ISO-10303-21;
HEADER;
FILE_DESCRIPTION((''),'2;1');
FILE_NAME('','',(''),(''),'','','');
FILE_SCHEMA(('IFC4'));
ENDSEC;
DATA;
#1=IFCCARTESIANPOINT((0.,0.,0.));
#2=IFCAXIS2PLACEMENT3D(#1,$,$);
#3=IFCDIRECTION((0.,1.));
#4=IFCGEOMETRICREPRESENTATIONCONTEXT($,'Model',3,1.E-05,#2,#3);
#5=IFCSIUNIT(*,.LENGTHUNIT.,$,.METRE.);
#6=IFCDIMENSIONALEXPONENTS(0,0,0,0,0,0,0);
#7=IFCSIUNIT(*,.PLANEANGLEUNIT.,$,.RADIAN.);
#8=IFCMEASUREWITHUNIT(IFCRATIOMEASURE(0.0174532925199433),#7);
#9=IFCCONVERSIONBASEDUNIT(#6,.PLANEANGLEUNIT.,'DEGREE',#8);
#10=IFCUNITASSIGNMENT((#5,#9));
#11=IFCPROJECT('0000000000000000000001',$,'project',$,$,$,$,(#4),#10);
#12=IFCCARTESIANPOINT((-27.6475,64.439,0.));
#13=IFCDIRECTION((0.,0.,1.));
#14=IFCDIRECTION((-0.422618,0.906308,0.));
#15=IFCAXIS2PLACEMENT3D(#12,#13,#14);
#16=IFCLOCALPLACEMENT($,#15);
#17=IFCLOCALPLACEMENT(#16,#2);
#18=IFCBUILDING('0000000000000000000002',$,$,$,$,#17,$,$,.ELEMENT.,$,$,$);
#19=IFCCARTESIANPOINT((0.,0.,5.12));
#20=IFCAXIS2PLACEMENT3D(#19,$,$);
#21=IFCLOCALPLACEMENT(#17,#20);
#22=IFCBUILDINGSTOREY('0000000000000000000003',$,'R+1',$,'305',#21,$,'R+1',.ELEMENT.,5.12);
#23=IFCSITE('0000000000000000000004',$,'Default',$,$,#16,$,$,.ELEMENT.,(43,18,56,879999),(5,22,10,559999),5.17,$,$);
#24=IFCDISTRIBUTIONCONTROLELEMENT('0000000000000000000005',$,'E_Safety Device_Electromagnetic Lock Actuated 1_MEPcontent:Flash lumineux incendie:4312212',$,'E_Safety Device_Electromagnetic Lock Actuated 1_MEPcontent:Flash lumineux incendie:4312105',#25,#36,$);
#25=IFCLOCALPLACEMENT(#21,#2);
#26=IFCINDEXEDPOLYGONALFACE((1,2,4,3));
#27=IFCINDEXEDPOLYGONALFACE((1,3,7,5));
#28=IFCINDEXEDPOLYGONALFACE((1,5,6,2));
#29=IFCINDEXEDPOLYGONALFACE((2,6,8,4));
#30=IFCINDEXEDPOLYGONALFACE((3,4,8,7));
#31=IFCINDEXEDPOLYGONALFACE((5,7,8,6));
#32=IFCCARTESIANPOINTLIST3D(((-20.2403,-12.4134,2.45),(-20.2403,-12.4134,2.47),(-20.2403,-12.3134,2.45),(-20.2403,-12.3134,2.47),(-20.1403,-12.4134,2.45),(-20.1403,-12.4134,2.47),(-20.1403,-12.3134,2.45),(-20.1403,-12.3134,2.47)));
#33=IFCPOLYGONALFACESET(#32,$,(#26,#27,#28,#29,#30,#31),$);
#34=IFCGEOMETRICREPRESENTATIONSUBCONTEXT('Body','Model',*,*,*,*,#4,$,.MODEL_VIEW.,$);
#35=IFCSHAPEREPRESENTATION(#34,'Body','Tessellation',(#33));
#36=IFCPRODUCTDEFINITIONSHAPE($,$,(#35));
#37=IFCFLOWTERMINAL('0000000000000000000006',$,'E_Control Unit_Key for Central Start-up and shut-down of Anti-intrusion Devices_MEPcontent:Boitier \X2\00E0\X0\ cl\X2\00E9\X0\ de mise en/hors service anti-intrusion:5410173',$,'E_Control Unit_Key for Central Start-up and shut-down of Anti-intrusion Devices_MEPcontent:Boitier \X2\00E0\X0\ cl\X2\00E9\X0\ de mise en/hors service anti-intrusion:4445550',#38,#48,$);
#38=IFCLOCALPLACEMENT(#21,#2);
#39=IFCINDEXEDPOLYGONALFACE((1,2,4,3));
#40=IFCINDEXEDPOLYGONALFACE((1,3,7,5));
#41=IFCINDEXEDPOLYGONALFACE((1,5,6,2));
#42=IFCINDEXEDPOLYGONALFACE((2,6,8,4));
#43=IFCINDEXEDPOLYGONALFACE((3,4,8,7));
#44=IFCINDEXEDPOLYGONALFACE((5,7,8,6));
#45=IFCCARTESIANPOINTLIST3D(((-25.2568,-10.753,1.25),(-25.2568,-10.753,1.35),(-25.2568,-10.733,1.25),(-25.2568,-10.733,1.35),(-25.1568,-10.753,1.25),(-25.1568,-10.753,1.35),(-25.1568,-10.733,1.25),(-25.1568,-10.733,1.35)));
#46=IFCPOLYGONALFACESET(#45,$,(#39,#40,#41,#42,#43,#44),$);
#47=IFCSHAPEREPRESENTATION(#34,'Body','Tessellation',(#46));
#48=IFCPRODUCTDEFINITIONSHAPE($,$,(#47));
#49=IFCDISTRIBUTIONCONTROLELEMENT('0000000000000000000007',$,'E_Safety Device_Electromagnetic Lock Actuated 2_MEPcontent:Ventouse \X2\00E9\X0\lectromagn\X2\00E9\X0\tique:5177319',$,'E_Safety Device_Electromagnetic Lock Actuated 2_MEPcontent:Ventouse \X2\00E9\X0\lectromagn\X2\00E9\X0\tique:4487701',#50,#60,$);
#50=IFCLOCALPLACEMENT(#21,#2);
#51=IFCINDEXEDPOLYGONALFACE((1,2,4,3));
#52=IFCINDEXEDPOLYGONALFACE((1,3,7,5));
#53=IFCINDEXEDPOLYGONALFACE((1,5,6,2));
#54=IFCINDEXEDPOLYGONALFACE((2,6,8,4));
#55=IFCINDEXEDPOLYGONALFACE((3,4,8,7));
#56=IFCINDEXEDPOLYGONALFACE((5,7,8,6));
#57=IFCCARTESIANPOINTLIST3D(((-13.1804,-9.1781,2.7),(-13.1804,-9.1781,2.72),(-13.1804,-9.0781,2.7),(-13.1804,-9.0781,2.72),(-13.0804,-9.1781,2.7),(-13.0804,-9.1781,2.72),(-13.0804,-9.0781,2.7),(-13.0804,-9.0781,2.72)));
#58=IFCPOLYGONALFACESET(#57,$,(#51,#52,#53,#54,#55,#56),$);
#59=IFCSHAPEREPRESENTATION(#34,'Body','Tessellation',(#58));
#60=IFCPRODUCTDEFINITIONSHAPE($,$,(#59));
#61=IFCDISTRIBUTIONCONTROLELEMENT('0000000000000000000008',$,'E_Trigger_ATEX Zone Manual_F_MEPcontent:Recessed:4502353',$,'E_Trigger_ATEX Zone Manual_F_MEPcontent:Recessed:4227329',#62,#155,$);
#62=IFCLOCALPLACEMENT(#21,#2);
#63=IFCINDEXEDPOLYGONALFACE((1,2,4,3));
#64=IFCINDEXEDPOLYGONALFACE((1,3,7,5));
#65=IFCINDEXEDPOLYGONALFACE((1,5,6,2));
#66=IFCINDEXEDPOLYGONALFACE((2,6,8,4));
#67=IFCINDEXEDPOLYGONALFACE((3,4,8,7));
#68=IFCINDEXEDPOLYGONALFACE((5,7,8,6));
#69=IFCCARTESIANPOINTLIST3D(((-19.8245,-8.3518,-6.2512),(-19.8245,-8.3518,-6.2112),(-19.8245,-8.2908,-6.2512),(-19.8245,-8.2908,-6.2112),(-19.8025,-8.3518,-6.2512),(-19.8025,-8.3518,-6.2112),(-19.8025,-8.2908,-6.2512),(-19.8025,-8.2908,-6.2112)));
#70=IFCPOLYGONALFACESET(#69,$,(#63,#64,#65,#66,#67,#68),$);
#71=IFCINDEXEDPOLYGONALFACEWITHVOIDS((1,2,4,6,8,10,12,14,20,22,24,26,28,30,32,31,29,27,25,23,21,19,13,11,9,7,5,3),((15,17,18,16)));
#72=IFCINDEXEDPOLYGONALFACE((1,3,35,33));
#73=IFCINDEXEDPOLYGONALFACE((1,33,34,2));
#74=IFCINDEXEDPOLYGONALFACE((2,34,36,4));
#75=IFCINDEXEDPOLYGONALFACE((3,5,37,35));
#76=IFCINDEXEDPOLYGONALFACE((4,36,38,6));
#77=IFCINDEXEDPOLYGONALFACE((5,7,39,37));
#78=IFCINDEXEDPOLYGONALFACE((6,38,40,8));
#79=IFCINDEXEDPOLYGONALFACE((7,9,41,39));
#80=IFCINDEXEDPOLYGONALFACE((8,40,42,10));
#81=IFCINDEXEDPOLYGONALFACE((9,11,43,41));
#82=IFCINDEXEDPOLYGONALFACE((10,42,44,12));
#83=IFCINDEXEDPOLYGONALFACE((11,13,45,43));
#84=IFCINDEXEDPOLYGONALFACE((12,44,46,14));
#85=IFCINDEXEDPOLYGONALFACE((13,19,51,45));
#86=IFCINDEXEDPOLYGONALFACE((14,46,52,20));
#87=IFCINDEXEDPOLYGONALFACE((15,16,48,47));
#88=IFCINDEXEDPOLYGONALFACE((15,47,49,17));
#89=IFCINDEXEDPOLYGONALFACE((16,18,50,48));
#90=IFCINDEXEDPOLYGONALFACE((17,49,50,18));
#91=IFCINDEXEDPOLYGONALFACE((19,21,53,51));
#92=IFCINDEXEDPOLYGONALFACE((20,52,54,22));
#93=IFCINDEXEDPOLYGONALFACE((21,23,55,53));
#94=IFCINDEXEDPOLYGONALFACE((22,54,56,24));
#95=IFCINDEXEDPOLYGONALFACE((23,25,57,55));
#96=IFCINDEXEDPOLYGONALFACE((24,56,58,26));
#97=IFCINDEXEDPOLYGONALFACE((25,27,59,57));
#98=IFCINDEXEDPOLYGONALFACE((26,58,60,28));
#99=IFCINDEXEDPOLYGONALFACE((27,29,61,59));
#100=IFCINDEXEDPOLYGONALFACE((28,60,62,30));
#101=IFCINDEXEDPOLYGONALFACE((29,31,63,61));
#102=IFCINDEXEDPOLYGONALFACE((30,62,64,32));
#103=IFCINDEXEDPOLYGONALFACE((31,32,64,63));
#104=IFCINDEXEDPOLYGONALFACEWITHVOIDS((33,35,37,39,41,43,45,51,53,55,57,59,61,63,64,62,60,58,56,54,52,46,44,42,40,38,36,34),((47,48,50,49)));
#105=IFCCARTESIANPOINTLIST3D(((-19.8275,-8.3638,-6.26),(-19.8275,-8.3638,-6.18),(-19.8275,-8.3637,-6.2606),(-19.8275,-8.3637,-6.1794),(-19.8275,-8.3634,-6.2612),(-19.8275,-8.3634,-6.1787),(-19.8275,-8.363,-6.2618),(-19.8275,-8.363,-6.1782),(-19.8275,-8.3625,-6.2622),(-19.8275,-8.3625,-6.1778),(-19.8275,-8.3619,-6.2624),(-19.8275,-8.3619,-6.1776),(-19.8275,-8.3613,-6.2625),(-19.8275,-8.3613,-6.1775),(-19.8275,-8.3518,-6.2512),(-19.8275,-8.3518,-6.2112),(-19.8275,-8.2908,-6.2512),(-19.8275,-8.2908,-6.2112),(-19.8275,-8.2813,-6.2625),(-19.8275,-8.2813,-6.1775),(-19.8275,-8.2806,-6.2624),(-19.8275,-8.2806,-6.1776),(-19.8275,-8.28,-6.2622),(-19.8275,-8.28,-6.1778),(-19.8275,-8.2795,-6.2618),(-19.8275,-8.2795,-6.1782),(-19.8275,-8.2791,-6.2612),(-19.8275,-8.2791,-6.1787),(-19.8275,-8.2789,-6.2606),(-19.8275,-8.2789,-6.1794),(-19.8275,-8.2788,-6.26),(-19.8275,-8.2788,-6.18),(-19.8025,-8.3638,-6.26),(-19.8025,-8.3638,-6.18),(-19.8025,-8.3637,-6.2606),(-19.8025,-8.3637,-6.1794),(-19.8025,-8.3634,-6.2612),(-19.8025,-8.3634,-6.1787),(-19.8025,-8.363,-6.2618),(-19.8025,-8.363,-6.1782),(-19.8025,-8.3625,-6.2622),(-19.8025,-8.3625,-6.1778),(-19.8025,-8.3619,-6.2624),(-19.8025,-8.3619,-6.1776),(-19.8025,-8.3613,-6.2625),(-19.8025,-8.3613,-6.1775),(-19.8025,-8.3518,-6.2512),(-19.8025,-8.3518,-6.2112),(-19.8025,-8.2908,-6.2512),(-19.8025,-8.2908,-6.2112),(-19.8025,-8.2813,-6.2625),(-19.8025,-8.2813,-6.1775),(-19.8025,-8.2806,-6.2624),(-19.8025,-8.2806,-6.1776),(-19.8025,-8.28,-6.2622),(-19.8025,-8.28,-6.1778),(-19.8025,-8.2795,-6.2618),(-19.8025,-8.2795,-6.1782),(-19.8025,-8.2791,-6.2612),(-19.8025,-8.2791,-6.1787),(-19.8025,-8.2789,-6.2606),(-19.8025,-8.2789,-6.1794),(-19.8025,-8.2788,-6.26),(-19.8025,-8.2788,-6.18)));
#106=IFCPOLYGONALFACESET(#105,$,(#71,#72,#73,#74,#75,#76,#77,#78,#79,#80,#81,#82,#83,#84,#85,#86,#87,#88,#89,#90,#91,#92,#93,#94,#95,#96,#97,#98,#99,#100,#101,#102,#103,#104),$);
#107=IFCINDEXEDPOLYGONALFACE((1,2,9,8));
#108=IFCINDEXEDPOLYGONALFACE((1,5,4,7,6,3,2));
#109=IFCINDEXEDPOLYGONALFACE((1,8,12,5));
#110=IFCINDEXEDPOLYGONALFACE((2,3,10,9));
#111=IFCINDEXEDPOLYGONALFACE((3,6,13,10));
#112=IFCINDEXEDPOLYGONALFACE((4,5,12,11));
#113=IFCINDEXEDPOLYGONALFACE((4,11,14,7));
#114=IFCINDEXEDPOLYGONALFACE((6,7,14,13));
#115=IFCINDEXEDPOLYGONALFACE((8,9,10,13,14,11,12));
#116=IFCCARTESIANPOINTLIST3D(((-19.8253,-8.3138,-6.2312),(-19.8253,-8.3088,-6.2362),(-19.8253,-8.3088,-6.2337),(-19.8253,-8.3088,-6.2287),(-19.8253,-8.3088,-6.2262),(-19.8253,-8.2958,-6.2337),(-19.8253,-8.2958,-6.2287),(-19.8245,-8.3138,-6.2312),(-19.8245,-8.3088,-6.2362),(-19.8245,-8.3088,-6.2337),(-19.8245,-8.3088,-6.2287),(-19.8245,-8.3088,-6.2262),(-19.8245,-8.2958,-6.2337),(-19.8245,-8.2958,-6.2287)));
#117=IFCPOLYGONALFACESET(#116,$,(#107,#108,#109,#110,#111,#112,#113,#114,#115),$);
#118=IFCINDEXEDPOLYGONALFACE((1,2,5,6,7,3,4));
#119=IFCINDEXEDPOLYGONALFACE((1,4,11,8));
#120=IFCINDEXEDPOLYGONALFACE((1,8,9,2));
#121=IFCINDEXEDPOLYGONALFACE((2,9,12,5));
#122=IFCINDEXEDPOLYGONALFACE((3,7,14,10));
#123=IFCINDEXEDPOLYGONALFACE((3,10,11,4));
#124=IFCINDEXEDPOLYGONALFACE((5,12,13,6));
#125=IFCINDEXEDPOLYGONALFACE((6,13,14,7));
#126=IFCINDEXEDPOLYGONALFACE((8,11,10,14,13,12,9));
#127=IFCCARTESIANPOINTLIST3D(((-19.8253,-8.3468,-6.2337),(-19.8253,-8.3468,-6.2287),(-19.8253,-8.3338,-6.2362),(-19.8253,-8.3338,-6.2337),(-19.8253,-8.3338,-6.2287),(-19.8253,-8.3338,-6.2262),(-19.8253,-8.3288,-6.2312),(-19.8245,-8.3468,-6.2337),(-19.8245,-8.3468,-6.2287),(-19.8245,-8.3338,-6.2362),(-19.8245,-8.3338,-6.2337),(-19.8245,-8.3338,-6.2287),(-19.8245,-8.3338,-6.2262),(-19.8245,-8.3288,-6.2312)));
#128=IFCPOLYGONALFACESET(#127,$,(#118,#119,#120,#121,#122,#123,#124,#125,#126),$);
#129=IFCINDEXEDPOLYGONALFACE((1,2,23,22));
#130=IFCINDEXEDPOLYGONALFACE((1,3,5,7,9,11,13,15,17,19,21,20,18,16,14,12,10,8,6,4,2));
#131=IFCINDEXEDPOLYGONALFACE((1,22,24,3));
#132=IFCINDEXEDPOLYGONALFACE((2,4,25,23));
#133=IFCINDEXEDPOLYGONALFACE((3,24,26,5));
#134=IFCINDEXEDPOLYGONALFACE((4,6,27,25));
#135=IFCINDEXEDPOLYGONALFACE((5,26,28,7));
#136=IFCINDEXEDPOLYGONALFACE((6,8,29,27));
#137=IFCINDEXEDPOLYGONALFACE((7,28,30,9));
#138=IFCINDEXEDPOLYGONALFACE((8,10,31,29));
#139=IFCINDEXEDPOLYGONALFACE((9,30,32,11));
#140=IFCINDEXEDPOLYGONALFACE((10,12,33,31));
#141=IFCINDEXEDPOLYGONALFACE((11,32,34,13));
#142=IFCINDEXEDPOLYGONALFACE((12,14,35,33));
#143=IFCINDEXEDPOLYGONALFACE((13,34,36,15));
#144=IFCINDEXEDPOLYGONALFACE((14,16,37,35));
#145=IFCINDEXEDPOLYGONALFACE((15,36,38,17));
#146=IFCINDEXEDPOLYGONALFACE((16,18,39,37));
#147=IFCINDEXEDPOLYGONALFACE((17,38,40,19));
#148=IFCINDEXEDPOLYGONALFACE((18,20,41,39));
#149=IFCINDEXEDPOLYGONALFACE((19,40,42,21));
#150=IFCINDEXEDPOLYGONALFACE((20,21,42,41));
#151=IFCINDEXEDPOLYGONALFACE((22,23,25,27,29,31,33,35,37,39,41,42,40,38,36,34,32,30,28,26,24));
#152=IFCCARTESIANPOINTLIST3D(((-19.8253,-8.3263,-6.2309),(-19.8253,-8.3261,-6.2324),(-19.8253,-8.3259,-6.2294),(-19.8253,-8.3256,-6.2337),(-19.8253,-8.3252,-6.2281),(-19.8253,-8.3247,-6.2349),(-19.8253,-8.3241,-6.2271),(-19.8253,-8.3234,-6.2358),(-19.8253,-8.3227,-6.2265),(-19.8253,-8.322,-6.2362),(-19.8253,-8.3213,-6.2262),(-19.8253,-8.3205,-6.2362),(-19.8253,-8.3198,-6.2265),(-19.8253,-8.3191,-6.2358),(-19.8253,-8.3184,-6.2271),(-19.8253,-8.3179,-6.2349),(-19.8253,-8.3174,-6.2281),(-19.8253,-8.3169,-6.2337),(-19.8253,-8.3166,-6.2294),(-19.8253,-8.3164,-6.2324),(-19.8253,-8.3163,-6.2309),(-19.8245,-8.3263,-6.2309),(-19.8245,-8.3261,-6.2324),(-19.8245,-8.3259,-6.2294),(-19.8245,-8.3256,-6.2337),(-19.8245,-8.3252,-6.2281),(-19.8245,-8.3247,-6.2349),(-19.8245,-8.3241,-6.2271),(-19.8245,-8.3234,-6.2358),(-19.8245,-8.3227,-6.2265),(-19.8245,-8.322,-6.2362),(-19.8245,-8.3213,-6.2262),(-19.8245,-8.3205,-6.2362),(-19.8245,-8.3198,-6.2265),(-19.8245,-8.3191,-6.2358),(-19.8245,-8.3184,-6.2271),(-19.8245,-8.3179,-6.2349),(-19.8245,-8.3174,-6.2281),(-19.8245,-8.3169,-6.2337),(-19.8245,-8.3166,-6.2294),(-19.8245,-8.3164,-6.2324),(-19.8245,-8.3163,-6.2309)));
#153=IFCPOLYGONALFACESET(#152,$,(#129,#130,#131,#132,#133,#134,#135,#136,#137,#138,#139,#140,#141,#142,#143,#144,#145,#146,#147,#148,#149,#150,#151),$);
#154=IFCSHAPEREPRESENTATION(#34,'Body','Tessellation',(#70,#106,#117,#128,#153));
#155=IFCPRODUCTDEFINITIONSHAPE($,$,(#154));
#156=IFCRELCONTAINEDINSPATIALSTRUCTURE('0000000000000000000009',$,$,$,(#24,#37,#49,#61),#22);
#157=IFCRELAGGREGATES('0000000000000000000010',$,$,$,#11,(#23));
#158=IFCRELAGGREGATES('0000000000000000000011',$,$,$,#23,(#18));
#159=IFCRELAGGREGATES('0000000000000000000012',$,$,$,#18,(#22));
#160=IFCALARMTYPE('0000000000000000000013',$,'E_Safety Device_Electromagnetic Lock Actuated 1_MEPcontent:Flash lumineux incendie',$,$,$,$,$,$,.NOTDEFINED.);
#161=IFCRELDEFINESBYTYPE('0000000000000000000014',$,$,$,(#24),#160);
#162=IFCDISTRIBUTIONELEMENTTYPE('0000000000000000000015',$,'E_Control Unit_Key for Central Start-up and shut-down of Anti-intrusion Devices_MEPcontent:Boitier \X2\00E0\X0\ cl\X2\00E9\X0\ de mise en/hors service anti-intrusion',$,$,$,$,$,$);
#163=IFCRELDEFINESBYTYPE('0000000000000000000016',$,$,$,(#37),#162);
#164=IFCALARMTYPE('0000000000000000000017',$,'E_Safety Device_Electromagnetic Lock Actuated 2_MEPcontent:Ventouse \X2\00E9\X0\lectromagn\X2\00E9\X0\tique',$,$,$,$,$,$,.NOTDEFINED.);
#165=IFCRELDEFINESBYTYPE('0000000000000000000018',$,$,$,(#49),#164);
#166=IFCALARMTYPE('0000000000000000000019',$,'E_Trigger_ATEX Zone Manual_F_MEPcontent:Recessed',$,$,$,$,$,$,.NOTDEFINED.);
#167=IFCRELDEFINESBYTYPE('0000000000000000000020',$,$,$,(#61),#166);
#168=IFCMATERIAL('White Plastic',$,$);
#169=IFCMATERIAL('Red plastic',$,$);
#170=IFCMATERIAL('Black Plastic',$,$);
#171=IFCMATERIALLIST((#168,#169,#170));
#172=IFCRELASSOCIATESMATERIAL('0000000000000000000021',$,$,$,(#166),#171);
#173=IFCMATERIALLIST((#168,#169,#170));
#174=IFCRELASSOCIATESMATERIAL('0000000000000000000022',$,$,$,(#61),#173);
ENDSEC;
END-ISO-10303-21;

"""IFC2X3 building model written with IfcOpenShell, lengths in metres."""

from ifc_helpers import new_model, entity, si_unit, converted_unit, direction, frame, frame_2d, origin, origin_2d_with_axis, place, context, subcontext, project, spatial, polyline, circle_curve, parameter, trimmed, segment, composite_curve, rectangle, circle, outline, extrude, source, transform, mapped, material, material_list, type_object, type_shapes, element, save


model = new_model("IFC2X3")

# Units and contexts
model_context = context("Model", 3, precision=1e-05, world=origin(), true_north=direction((0.0, 1.0)))
body_context = subcontext(model_context, "Body", "Model", "MODEL_VIEW")
ifc_project = project(units=[si_unit("LENGTHUNIT", "METRE"), converted_unit("PLANEANGLEUNIT", "DEGREE", entity("IfcRatioMeasure", 0.0174532925199433), si_unit("PLANEANGLEUNIT", "RADIAN"), dimensions=[0, 0, 0, 0, 0, 0, 0])], contexts=[model_context])

# Site, building, storey
site_placement = place(None, frame((-27.6475, 64.439, 0.0), z_axis=(0.0, 0.0, 1.0), x_axis=(-0.422618, 0.906308, 0.0)))
site = spatial("IfcSite", under=ifc_project, at=site_placement, Name="Default", CompositionType="ELEMENT", RefLatitude=(43, 18, 56, 879999), RefLongitude=(5, 22, 10, 559999), RefElevation=5.17)
building_placement = place(site_placement, origin())
building = spatial("IfcBuilding", under=site, at=building_placement, CompositionType="ELEMENT")
storey_placement = place(building_placement, frame((0.0, 0.0, 5.12)))
storey = spatial("IfcBuildingStorey", under=building, at=storey_placement, Name="R+1", ObjectType="305", LongName="R+1", CompositionType="ELEMENT", Elevation=5.12)

# Distribution control element
alarm_type_1 = type_object("IfcAlarmType", Name="E_Safety Device_Electromagnetic Lock Actuated 1_MEPcontent:Flash lumineux incendie", PredefinedType="NOTDEFINED")
shared_shape_1 = source(origin(), body_context, "Body", "SweptSolid", [
    extrude(rectangle(XDim=0.1, YDim=0.1, at=origin_2d_with_axis()), frame((0.0, 0.0, 0.0), z_axis=(0.0, 0.0, 1.0), x_axis=(0.0, -1.0, 0.0)), (0.0, 0.0, 1.0), 0.02),
])
type_shapes(alarm_type_1, [shared_shape_1])
distribution_control_element_1_placement = place(storey_placement, frame((-20.1903, -12.3634, 2.45), z_axis=(0.0, 0.0, 1.0), x_axis=(0.0, -1.0, 0.0)))
element("IfcDistributionControlElement", 1, at=distribution_control_element_1_placement, inside=storey, type_object=alarm_type_1, Name="E_Safety Device_Electromagnetic Lock Actuated 1_MEPcontent:Flash lumineux incendie:4312212", ObjectType="E_Safety Device_Electromagnetic Lock Actuated 1_MEPcontent:Flash lumineux incendie:4312105", context=body_context, shape_type="MappedRepresentation", body=[
    mapped(shared_shape_1, transform((0.0, 0.0, 0.0), scale=1.0)),
])

# Flow terminal
distribution_element_type_1 = type_object("IfcDistributionElementType", Name="E_Control Unit_Key for Central Start-up and shut-down of Anti-intrusion Devices_MEPcontent:Boitier à clé de mise en/hors service anti-intrusion")
shared_shape_2 = source(origin(), body_context, "Body", "SweptSolid", [
    extrude(rectangle(XDim=0.02, YDim=0.1, at=frame_2d((0.0, 0.0), x_axis=(1.0, 0.0))), frame((0.0, -0.01, -0.05), z_axis=(0.0, 0.0, 1.0), x_axis=(0.0, 1.0, 0.0)), (0.0, 0.0, 1.0), 0.1),
])
type_shapes(distribution_element_type_1, [shared_shape_2])
flow_terminal_1_placement = place(storey_placement, frame((-25.2068, -10.753, 1.3), z_axis=(0.0, 0.0, 1.0), x_axis=(-1.0, 0.0, 0.0)))
element("IfcFlowTerminal", 2, at=flow_terminal_1_placement, inside=storey, type_object=distribution_element_type_1, Name="E_Control Unit_Key for Central Start-up and shut-down of Anti-intrusion Devices_MEPcontent:Boitier à clé de mise en/hors service anti-intrusion:5410173", ObjectType="E_Control Unit_Key for Central Start-up and shut-down of Anti-intrusion Devices_MEPcontent:Boitier à clé de mise en/hors service anti-intrusion:4445550", context=body_context, shape_type="MappedRepresentation", body=[
    mapped(shared_shape_2, transform((0.0, 0.0, 0.0), scale=1.0)),
])

# Distribution control elements
alarm_type_2 = type_object("IfcAlarmType", Name="E_Safety Device_Electromagnetic Lock Actuated 2_MEPcontent:Ventouse électromagnétique", PredefinedType="NOTDEFINED")
shared_shape_3 = source(origin(), body_context, "Body", "SweptSolid", [
    extrude(rectangle(XDim=0.1, YDim=0.1, at=origin_2d_with_axis()), frame((0.0, 0.0, 0.0), z_axis=(0.0, 0.0, 1.0), x_axis=(0.0, -1.0, 0.0)), (0.0, 0.0, 1.0), 0.02),
])
type_shapes(alarm_type_2, [shared_shape_3])
distribution_control_element_2_placement = place(storey_placement, frame((-13.1304, -9.1281, 2.7), z_axis=(0.0, 0.0, 1.0), x_axis=(0.0, 1.0, 0.0)))
element("IfcDistributionControlElement", 3, at=distribution_control_element_2_placement, inside=storey, type_object=alarm_type_2, Name="E_Safety Device_Electromagnetic Lock Actuated 2_MEPcontent:Ventouse électromagnétique:5177319", ObjectType="E_Safety Device_Electromagnetic Lock Actuated 2_MEPcontent:Ventouse électromagnétique:4487701", context=body_context, shape_type="MappedRepresentation", body=[
    mapped(shared_shape_3, transform((0.0, 0.0, 0.0), scale=1.0)),
])
ifc_material_1 = material(Name="White Plastic")
ifc_material_2 = material(Name="Red plastic")
ifc_material_3 = material(Name="Black Plastic")
ifc_material_list_1 = material_list([ifc_material_1, ifc_material_2, ifc_material_3])
ifc_material_list_2 = material_list([ifc_material_1, ifc_material_2, ifc_material_3])
alarm_type_3 = type_object("IfcAlarmType", Name="E_Trigger_ATEX Zone Manual_F_MEPcontent:Recessed", PredefinedType="NOTDEFINED", material=ifc_material_list_2)
shared_shape_4 = source(origin(), body_context, "Body", "SweptSolid", [
    extrude(rectangle(XDim=0.061, YDim=0.04, at=origin_2d_with_axis()), frame((0.0, -0.0112, 0.0), z_axis=(0.0, 0.0, 1.0), x_axis=(-1.0, 0.0, 0.0)), (0.0, 0.0, 1.0), 0.022),
    extrude(outline(composite_curve([segment(polyline([(-0.04, -0.0425), (0.04, -0.0425)]), True, "CONTINUOUS"), segment(trimmed(circle_curve(frame_2d((0.04, -0.04), x_axis=(-1.0, 0.0)), 0.0025), [parameter(90.0)], [parameter(180.0)], True, "PARAMETER"), True, "CONTINUOUS"), segment(polyline([(0.0425, -0.04), (0.0425, 0.04)]), True, "CONTINUOUS"), segment(trimmed(circle_curve(frame_2d((0.04, 0.04), x_axis=(-1.0, 0.0)), 0.0025), [parameter(180.0)], [parameter(270.0)], True, "PARAMETER"), True, "CONTINUOUS"), segment(polyline([(0.04, 0.0425), (-0.04, 0.0425)]), True, "CONTINUOUS"), segment(trimmed(circle_curve(frame_2d((-0.04, 0.04), x_axis=(-1.0, 0.0)), 0.0025), [parameter(270.0)], [parameter(0.0)], True, "PARAMETER"), True, "CONTINUOUS"), segment(polyline([(-0.0425, 0.04), (-0.0425, -0.04)]), True, "CONTINUOUS"), segment(trimmed(circle_curve(frame_2d((-0.04, -0.04), x_axis=(-1.0, 0.0)), 0.0025), [parameter(360.0)], [parameter(90.0)], True, "PARAMETER"), True, "CONTINUOUS")], self_intersect=False), holes=[polyline([(-0.0305, -0.0088), (-0.0305, 0.0312), (0.0305, 0.0312), (0.0305, -0.0088), (-0.0305, -0.0088)])]), frame((0.0, 0.0, 0.0), z_axis=(0.0, 0.0, 1.0), x_axis=(-1.0, 0.0, 0.0)), (0.0, 0.0, 1.0), 0.025),
    extrude(outline(polyline([(-0.01, 0.0025), (-0.01, -0.0025), (0.003, -0.0025), (0.003, -0.005), (0.008, 0.0), (0.003, 0.005), (0.003, 0.0025), (-0.01, 0.0025)])), frame((-0.0155, -0.0112, 0.022), z_axis=(0.0, 0.0, -1.0), x_axis=(1.0, 0.0, 0.0)), (0.0, 0.0, -1.0), 0.0008),
    extrude(outline(polyline([(-0.0014, -0.0057), (0.0057, -0.0057), (0.0057, 0.0014), (0.0039, -0.0004), (-0.0053, 0.0088), (-0.0088, 0.0053), (0.0004, -0.0039), (-0.0014, -0.0057)])), frame((0.0155, -0.0112, 0.022), z_axis=(0.0, 0.0, 1.0), x_axis=(-0.707107, -0.707107, 0.0)), (0.0, 0.0, 1.0), 0.0008),
    extrude(circle(Radius=0.005, at=frame_2d((0.0, 0.0), x_axis=(1.0, 0.0))), frame((0.0, -0.0112, 0.022), z_axis=(0.0, 0.0, 1.0), x_axis=(0.0, 1.0, 0.0)), (0.0, 0.0, 1.0), 0.0008),
])
type_shapes(alarm_type_3, [shared_shape_4])
distribution_control_element_3_placement = place(storey_placement, frame((-19.8025, -8.3213, -6.22), z_axis=(-1.0, 0.0, 0.0), x_axis=(0.0, -1.0, 0.0)))
element("IfcDistributionControlElement", 4, at=distribution_control_element_3_placement, inside=storey, type_object=alarm_type_3, material=ifc_material_list_1, Name="E_Trigger_ATEX Zone Manual_F_MEPcontent:Recessed:4502353", ObjectType="E_Trigger_ATEX Zone Manual_F_MEPcontent:Recessed:4227329", context=body_context, shape_type="MappedRepresentation", body=[
    mapped(shared_shape_4, transform((0.0, 0.0, 0.0), scale=1.0)),
])

save(model, "model.ifc")
